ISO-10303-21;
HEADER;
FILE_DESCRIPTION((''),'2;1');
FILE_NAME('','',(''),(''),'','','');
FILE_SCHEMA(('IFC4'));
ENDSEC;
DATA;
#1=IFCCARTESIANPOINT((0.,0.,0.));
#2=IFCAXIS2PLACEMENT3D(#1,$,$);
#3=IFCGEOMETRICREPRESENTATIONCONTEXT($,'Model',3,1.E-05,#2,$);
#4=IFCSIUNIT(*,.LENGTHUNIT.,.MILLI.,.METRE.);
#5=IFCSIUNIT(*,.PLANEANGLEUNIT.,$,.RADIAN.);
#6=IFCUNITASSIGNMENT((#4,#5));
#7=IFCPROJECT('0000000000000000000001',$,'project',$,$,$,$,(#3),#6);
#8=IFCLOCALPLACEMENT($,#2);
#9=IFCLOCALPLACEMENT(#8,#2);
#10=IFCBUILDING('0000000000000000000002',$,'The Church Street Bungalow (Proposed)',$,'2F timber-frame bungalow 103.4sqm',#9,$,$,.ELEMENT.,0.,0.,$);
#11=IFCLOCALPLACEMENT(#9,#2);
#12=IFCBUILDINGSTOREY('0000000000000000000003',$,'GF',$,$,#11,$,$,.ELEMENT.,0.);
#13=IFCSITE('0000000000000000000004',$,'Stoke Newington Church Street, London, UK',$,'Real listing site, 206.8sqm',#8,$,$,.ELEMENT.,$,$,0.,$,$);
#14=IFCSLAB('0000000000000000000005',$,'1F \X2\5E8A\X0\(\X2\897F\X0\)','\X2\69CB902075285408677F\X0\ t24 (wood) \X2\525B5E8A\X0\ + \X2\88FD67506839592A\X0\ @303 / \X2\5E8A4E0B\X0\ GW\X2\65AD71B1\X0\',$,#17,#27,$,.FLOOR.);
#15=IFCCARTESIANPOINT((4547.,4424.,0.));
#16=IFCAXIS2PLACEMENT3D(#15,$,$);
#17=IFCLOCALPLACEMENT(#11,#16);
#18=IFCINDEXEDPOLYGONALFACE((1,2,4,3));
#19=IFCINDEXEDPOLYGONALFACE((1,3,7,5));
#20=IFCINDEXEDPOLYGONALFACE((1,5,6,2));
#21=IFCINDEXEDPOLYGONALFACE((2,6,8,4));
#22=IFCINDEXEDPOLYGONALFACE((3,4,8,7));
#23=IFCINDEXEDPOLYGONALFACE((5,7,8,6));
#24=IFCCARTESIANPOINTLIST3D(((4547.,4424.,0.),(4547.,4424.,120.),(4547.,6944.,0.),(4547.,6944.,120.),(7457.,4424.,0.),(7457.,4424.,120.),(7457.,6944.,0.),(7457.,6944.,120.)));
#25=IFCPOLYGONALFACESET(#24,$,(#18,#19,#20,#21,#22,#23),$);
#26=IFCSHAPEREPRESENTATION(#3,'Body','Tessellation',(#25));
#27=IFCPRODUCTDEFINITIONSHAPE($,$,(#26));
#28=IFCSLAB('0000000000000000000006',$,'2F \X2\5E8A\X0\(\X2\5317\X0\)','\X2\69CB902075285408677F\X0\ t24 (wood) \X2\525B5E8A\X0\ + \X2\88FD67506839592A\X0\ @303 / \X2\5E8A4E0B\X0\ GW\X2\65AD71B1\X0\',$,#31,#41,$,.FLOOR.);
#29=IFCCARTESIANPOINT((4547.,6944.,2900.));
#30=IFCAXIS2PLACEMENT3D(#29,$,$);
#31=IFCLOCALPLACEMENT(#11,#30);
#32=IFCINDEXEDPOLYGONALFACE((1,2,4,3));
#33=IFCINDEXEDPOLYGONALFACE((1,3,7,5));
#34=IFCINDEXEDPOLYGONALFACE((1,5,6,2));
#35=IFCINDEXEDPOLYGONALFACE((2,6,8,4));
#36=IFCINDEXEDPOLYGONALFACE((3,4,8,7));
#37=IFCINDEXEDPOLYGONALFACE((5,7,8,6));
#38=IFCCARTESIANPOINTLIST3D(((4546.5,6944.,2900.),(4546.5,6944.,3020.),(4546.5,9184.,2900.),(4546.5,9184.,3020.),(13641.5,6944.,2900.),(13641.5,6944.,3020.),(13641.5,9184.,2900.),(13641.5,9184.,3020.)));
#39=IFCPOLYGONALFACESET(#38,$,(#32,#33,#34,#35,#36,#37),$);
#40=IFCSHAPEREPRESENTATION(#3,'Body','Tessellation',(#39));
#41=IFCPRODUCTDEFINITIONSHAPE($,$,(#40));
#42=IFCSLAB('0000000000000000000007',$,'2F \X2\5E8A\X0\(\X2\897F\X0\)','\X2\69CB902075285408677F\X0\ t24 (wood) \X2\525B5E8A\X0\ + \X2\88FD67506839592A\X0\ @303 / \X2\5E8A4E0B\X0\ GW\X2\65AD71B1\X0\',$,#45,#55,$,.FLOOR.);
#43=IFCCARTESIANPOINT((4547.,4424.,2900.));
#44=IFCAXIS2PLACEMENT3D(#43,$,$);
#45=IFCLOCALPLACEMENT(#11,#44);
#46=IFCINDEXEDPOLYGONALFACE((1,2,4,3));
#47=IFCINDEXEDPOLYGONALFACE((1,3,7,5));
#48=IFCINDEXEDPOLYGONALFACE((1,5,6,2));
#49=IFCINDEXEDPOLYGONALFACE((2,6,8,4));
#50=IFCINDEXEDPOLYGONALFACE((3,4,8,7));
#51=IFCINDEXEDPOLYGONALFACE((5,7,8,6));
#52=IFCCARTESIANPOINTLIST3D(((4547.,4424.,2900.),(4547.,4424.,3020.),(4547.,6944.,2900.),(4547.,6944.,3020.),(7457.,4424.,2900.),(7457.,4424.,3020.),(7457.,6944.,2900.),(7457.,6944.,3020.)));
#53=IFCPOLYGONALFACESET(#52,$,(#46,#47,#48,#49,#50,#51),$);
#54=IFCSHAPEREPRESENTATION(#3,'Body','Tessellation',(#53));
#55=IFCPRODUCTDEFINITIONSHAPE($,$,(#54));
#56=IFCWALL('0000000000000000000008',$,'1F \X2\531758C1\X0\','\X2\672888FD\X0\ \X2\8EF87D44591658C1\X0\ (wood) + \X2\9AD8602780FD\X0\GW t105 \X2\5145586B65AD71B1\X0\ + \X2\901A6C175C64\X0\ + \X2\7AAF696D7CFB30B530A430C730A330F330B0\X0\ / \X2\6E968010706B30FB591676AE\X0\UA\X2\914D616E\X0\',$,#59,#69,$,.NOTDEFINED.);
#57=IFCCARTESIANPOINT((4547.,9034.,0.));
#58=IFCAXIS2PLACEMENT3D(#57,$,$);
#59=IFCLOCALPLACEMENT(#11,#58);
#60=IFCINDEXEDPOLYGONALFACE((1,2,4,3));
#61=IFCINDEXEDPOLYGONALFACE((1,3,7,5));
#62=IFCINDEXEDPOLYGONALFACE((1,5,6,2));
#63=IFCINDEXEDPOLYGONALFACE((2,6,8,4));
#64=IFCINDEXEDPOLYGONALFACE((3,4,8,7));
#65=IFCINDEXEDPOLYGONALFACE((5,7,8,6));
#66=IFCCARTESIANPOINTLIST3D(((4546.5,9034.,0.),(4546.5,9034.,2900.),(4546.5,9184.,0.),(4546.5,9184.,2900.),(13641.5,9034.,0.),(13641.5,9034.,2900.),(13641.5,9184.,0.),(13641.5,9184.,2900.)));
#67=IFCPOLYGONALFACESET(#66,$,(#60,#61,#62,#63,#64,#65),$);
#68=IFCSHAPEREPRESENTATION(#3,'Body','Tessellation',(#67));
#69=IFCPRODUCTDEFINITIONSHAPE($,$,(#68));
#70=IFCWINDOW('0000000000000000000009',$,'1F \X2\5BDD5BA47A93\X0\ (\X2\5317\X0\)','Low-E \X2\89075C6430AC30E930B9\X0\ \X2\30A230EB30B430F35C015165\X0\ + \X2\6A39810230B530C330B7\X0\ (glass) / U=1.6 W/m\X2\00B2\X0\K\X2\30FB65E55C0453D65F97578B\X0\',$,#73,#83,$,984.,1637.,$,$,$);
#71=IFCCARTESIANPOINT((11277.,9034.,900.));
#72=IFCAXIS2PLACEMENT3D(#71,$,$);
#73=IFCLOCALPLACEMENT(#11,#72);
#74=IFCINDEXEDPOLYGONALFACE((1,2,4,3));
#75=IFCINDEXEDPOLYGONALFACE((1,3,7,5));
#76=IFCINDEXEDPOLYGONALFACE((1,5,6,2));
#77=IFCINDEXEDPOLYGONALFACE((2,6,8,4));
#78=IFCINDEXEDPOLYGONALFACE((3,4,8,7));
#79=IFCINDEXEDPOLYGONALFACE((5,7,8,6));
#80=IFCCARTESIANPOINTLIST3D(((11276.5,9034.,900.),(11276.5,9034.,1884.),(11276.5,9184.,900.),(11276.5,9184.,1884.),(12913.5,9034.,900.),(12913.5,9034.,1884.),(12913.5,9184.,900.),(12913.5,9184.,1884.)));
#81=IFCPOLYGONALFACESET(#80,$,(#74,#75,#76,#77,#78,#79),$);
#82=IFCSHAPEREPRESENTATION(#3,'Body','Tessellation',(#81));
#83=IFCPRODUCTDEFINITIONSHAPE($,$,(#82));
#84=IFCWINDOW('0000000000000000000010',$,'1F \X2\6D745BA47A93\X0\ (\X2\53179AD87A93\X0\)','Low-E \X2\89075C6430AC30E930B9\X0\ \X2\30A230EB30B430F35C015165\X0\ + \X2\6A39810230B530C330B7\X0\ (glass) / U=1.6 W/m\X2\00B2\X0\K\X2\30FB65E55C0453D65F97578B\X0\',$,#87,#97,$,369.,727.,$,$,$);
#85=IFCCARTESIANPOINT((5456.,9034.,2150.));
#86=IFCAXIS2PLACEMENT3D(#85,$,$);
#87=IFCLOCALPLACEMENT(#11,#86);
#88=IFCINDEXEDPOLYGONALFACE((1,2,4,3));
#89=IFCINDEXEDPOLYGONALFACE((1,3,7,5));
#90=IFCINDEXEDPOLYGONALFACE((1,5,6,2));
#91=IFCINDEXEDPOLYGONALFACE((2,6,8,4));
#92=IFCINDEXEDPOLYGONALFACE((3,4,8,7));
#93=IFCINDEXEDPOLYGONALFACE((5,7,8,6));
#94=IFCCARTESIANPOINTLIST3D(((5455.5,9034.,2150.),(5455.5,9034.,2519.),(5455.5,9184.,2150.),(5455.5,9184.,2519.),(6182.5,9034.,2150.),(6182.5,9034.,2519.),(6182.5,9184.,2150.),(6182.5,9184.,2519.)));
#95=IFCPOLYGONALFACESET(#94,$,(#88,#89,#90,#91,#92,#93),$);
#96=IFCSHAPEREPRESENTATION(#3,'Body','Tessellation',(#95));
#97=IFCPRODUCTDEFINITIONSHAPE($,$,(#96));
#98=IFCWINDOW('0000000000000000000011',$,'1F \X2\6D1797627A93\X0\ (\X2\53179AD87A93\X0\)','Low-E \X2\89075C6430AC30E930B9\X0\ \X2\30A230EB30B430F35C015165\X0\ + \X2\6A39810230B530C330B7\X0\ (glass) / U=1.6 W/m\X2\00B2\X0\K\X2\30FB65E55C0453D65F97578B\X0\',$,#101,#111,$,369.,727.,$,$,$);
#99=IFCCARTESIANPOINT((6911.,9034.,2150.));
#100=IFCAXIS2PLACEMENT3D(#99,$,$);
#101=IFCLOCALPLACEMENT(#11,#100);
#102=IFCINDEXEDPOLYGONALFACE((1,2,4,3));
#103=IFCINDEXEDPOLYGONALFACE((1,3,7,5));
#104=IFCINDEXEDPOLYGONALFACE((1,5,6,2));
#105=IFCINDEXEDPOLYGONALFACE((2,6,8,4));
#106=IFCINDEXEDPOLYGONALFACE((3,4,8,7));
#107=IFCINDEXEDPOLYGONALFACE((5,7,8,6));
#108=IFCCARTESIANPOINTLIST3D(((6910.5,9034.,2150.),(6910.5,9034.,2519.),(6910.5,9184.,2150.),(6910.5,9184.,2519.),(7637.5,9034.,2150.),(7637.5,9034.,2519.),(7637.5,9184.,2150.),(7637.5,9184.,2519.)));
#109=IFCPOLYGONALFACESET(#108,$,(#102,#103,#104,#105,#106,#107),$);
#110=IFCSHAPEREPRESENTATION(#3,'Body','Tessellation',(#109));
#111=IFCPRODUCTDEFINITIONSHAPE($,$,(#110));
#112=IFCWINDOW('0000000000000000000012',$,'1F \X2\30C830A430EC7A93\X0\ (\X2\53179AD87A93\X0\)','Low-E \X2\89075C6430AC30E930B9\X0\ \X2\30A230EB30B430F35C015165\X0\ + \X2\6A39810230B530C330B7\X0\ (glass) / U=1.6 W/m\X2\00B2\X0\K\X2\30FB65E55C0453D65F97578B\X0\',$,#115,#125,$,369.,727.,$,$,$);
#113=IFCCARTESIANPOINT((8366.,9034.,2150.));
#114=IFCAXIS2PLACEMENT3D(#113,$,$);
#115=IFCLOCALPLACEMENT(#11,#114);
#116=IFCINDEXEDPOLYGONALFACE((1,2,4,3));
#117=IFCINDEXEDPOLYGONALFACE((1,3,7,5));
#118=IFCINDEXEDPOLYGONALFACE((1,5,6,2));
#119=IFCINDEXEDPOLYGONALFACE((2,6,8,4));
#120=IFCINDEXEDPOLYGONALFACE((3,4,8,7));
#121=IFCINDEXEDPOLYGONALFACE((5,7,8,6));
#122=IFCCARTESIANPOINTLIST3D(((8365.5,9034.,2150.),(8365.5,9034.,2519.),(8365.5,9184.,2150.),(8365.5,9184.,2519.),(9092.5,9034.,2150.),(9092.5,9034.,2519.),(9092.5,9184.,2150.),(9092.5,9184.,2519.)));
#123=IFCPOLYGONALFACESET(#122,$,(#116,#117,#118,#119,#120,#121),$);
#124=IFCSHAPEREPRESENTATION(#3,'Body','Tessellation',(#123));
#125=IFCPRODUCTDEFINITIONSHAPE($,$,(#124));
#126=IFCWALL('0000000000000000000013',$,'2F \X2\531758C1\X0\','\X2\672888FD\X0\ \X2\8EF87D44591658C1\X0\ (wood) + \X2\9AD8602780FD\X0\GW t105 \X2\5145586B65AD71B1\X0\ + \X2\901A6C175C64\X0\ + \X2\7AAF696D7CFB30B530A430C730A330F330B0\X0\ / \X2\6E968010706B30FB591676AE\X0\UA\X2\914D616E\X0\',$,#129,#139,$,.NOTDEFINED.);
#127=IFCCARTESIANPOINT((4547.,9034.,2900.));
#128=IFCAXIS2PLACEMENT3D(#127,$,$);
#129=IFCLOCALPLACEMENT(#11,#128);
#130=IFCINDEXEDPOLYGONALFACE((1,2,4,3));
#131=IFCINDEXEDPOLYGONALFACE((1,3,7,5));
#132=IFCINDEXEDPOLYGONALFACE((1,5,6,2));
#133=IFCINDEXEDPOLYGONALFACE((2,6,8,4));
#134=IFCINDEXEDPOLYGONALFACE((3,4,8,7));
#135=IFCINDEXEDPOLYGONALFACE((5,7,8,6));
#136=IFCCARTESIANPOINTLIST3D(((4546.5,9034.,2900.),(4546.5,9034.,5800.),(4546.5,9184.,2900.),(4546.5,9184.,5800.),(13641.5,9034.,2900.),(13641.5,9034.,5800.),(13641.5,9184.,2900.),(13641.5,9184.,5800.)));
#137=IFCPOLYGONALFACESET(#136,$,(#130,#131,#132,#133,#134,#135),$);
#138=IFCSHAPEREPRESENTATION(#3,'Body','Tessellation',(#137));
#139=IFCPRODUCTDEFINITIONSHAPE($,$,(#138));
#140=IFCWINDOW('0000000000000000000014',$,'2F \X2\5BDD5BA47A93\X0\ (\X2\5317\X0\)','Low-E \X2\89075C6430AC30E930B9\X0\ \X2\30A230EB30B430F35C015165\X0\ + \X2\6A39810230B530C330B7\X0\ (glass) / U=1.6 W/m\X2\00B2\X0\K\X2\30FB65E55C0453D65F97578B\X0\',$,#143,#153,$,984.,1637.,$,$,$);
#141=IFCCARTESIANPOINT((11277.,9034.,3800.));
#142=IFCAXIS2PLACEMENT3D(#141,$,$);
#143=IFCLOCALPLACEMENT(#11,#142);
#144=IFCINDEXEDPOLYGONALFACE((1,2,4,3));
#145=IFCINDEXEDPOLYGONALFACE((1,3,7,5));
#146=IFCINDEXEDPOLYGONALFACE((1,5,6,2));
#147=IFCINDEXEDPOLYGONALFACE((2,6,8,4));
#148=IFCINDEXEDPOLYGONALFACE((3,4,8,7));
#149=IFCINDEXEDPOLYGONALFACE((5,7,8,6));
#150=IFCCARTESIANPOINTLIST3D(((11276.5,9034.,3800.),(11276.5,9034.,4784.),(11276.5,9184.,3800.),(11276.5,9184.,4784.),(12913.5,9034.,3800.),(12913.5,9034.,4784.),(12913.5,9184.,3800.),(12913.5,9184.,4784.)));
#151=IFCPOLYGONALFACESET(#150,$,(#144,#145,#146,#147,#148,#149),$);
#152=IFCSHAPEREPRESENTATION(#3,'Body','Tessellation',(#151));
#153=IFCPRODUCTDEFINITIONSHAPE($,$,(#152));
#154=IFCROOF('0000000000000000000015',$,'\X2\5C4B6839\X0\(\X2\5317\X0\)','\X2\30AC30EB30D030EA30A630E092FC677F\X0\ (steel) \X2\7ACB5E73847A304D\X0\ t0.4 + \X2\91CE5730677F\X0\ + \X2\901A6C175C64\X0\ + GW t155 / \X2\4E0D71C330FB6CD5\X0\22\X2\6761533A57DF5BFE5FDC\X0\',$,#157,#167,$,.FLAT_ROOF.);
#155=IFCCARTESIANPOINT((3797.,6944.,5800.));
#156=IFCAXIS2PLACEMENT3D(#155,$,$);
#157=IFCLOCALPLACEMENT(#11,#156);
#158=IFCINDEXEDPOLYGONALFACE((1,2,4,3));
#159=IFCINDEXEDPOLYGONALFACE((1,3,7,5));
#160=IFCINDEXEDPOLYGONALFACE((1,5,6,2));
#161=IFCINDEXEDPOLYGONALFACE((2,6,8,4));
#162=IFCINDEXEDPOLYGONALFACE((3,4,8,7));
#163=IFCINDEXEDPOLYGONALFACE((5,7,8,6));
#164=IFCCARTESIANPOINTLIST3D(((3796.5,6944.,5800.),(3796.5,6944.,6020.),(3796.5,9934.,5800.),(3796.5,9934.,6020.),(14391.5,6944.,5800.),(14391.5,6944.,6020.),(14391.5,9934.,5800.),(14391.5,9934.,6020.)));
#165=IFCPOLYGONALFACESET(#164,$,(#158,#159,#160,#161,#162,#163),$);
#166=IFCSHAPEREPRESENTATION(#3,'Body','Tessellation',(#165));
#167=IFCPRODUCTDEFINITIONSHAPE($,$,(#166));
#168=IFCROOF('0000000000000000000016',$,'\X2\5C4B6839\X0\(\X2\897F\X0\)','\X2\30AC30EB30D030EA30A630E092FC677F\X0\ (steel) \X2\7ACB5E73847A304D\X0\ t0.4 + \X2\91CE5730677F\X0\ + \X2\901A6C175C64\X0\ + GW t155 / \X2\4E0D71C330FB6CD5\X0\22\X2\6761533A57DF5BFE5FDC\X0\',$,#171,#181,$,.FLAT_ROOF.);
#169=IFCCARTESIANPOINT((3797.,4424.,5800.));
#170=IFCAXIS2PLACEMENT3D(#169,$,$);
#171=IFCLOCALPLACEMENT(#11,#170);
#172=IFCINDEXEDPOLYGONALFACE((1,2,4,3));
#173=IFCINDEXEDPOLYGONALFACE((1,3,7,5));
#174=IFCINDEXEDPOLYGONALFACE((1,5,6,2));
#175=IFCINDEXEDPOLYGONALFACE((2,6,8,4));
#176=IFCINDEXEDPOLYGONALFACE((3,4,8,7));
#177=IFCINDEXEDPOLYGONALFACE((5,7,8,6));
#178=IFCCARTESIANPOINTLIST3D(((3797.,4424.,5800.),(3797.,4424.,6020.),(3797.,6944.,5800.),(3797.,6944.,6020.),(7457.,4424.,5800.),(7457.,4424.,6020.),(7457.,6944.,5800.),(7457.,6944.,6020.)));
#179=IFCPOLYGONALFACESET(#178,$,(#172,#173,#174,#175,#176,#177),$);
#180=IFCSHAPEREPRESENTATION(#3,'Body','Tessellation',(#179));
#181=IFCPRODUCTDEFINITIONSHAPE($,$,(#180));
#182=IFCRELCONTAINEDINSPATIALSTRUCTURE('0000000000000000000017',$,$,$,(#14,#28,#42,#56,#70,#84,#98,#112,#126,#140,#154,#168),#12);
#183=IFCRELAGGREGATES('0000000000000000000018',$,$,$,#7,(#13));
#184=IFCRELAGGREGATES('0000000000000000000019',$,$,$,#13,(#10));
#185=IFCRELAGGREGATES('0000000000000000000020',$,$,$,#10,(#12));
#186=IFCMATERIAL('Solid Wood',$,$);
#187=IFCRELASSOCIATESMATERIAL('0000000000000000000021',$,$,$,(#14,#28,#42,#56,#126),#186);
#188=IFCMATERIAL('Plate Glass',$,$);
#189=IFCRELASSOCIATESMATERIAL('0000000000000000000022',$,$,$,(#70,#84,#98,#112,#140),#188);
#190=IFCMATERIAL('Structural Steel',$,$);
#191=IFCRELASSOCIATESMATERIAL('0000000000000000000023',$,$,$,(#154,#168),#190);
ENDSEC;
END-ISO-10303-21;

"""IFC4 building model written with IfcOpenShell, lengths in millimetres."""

from ifc_helpers import new_model, si_unit, frame, frame_2d, origin, place, context, project, spatial, rectangle, extrude, material, element, fill, save


model = new_model("IFC4")

# Units and contexts
model_context = context("Model", 3, precision=1e-05, world=origin())
ifc_project = project(units=[si_unit("LENGTHUNIT", "METRE", prefix="MILLI"), si_unit("PLANEANGLEUNIT", "RADIAN")], contexts=[model_context])

# Site, building, storey
site_placement = place(None, origin())
site = spatial("IfcSite", under=ifc_project, at=site_placement, Name="Stoke Newington Church Street, London, UK", ObjectType="Real listing site, 206.8sqm", CompositionType="ELEMENT", RefElevation=0.0)
building_placement = place(site_placement, origin())
building = spatial("IfcBuilding", under=site, at=building_placement, Name="The Church Street Bungalow (Proposed)", ObjectType="2F timber-frame bungalow 103.4sqm", CompositionType="ELEMENT", ElevationOfRefHeight=0.0, ElevationOfTerrain=0.0)
storey_placement = place(building_placement, origin())
storey = spatial("IfcBuildingStorey", under=building, at=storey_placement, Name="GF", CompositionType="ELEMENT", Elevation=0.0)

# Slabs
ifc_material_1 = material(Name="Solid Wood")
slab_1_placement = place(storey_placement, frame((4547.0, 4424.0, 0.0)))
element("IfcSlab", 1, at=slab_1_placement, inside=storey, material=ifc_material_1, Name="1F 床(西)", Description="構造用合板 t24 (wood) 剛床 + 製材根太 @303 / 床下 GW断熱", PredefinedType="FLOOR", context=model_context, shape_type="SweptSolid", body=[
    extrude(rectangle(XDim=2910.0, YDim=2520.0, at=frame_2d((1455.0, 1260.0))), frame((4547.0, 4424.0, 0.0)), (0.0, 0.0, 1.0), 120.0),
])
slab_2_placement = place(storey_placement, frame((4547.0, 6944.0, 2900.0)))
element("IfcSlab", 2, at=slab_2_placement, inside=storey, material=ifc_material_1, Name="2F 床(北)", Description="構造用合板 t24 (wood) 剛床 + 製材根太 @303 / 床下 GW断熱", PredefinedType="FLOOR", context=model_context, shape_type="SweptSolid", body=[
    extrude(rectangle(XDim=9095.0, YDim=2240.0, at=frame_2d((4547.0, 1120.0))), frame((4547.0, 6944.0, 2900.0)), (0.0, 0.0, 1.0), 120.0),
])
slab_3_placement = place(storey_placement, frame((4547.0, 4424.0, 2900.0)))
element("IfcSlab", 3, at=slab_3_placement, inside=storey, material=ifc_material_1, Name="2F 床(西)", Description="構造用合板 t24 (wood) 剛床 + 製材根太 @303 / 床下 GW断熱", PredefinedType="FLOOR", context=model_context, shape_type="SweptSolid", body=[
    extrude(rectangle(XDim=2910.0, YDim=2520.0, at=frame_2d((1455.0, 1260.0))), frame((4547.0, 4424.0, 2900.0)), (0.0, 0.0, 1.0), 120.0),
])

# Wall, openings, windows
wall_1_placement = place(storey_placement, frame((4547.0, 9034.0, 0.0)))
wall_1 = element("IfcWall", 4, at=wall_1_placement, inside=storey, material=ifc_material_1, Name="1F 北壁", Description="木製 軸組外壁 (wood) + 高性能GW t105 充填断熱 + 通気層 + 窯業系サイディング / 準耐火・外皮UA配慮", PredefinedType="NOTDEFINED", context=model_context, shape_type="SweptSolid", body=[
    extrude(rectangle(XDim=9095.0, YDim=150.0, at=frame_2d((4547.0, 75.0))), frame((4547.0, 9034.0, 0.0)), (0.0, 0.0, 1.0), 2900.0),
])
opening_1_placement = place(storey_placement, frame((11277.0, 9034.0, 900.0)))
opening_1 = element("IfcOpeningElement", 5, at=opening_1_placement, cuts=wall_1, PredefinedType="NOTDEFINED", context=model_context, shape_type="SweptSolid", body=[
    extrude(rectangle(XDim=1637.0, YDim=150.0, at=frame_2d((818.0, 75.0))), frame((11277.0, 9034.0, 900.0)), (0.0, 0.0, 1.0), 984.0),
])
opening_2_placement = place(storey_placement, frame((5456.0, 9034.0, 2150.0)))
opening_2 = element("IfcOpeningElement", 6, at=opening_2_placement, cuts=wall_1, PredefinedType="NOTDEFINED", context=model_context, shape_type="SweptSolid", body=[
    extrude(rectangle(XDim=727.0, YDim=150.0, at=frame_2d((363.0, 75.0))), frame((5456.0, 9034.0, 2150.0)), (0.0, 0.0, 1.0), 369.0),
])
opening_3_placement = place(storey_placement, frame((6911.0, 9034.0, 2150.0)))
opening_3 = element("IfcOpeningElement", 7, at=opening_3_placement, cuts=wall_1, PredefinedType="NOTDEFINED", context=model_context, shape_type="SweptSolid", body=[
    extrude(rectangle(XDim=727.0, YDim=150.0, at=frame_2d((363.0, 75.0))), frame((6911.0, 9034.0, 2150.0)), (0.0, 0.0, 1.0), 369.0),
])
opening_4_placement = place(storey_placement, frame((8366.0, 9034.0, 2150.0)))
opening_4 = element("IfcOpeningElement", 8, at=opening_4_placement, cuts=wall_1, PredefinedType="NOTDEFINED", context=model_context, shape_type="SweptSolid", body=[
    extrude(rectangle(XDim=727.0, YDim=150.0, at=frame_2d((363.0, 75.0))), frame((8366.0, 9034.0, 2150.0)), (0.0, 0.0, 1.0), 369.0),
])
ifc_material_2 = material(Name="Plate Glass")
window_1_placement = place(storey_placement, frame((11277.0, 9034.0, 900.0)))
window_1 = element("IfcWindow", 9, at=window_1_placement, inside=storey, material=ifc_material_2, Name="1F 寝室窓 (北)", Description="Low-E 複層ガラス アルゴン封入 + 樹脂サッシ (glass) / U=1.6 W/m²K・日射取得型", OverallHeight=984.0, OverallWidth=1637.0, context=model_context, shape_type="SweptSolid", body=[
    extrude(rectangle(XDim=1637.0, YDim=150.0, at=frame_2d((818.0, 75.0))), frame((11277.0, 9034.0, 900.0)), (0.0, 0.0, 1.0), 984.0),
])
fill(opening_1, window_1)
window_2_placement = place(storey_placement, frame((5456.0, 9034.0, 2150.0)))
window_2 = element("IfcWindow", 10, at=window_2_placement, inside=storey, material=ifc_material_2, Name="1F 浴室窓 (北高窓)", Description="Low-E 複層ガラス アルゴン封入 + 樹脂サッシ (glass) / U=1.6 W/m²K・日射取得型", OverallHeight=369.0, OverallWidth=727.0, context=model_context, shape_type="SweptSolid", body=[
    extrude(rectangle(XDim=727.0, YDim=150.0, at=frame_2d((363.0, 75.0))), frame((5456.0, 9034.0, 2150.0)), (0.0, 0.0, 1.0), 369.0),
])
fill(opening_2, window_2)
window_3_placement = place(storey_placement, frame((6911.0, 9034.0, 2150.0)))
window_3 = element("IfcWindow", 11, at=window_3_placement, inside=storey, material=ifc_material_2, Name="1F 洗面窓 (北高窓)", Description="Low-E 複層ガラス アルゴン封入 + 樹脂サッシ (glass) / U=1.6 W/m²K・日射取得型", OverallHeight=369.0, OverallWidth=727.0, context=model_context, shape_type="SweptSolid", body=[
    extrude(rectangle(XDim=727.0, YDim=150.0, at=frame_2d((363.0, 75.0))), frame((6911.0, 9034.0, 2150.0)), (0.0, 0.0, 1.0), 369.0),
])
fill(opening_3, window_3)
window_4_placement = place(storey_placement, frame((8366.0, 9034.0, 2150.0)))
window_4 = element("IfcWindow", 12, at=window_4_placement, inside=storey, material=ifc_material_2, Name="1F トイレ窓 (北高窓)", Description="Low-E 複層ガラス アルゴン封入 + 樹脂サッシ (glass) / U=1.6 W/m²K・日射取得型", OverallHeight=369.0, OverallWidth=727.0, context=model_context, shape_type="SweptSolid", body=[
    extrude(rectangle(XDim=727.0, YDim=150.0, at=frame_2d((363.0, 75.0))), frame((8366.0, 9034.0, 2150.0)), (0.0, 0.0, 1.0), 369.0),
])
fill(opening_4, window_4)

# Wall, opening, window
wall_2_placement = place(storey_placement, frame((4547.0, 9034.0, 2900.0)))
wall_2 = element("IfcWall", 13, at=wall_2_placement, inside=storey, material=ifc_material_1, Name="2F 北壁", Description="木製 軸組外壁 (wood) + 高性能GW t105 充填断熱 + 通気層 + 窯業系サイディング / 準耐火・外皮UA配慮", PredefinedType="NOTDEFINED", context=model_context, shape_type="SweptSolid", body=[
    extrude(rectangle(XDim=9095.0, YDim=150.0, at=frame_2d((4547.0, 75.0))), frame((4547.0, 9034.0, 2900.0)), (0.0, 0.0, 1.0), 2900.0),
])
opening_5_placement = place(storey_placement, frame((11277.0, 9034.0, 3800.0)))
opening_5 = element("IfcOpeningElement", 14, at=opening_5_placement, cuts=wall_2, PredefinedType="NOTDEFINED", context=model_context, shape_type="SweptSolid", body=[
    extrude(rectangle(XDim=1637.0, YDim=150.0, at=frame_2d((818.0, 75.0))), frame((11277.0, 9034.0, 3800.0)), (0.0, 0.0, 1.0), 984.0),
])
window_5_placement = place(storey_placement, frame((11277.0, 9034.0, 3800.0)))
window_5 = element("IfcWindow", 15, at=window_5_placement, inside=storey, material=ifc_material_2, Name="2F 寝室窓 (北)", Description="Low-E 複層ガラス アルゴン封入 + 樹脂サッシ (glass) / U=1.6 W/m²K・日射取得型", OverallHeight=984.0, OverallWidth=1637.0, context=model_context, shape_type="SweptSolid", body=[
    extrude(rectangle(XDim=1637.0, YDim=150.0, at=frame_2d((818.0, 75.0))), frame((11277.0, 9034.0, 3800.0)), (0.0, 0.0, 1.0), 984.0),
])
fill(opening_5, window_5)

# Roofs
ifc_material_3 = material(Name="Structural Steel")
for number, where, name in (
    (16, (3797.0, 6944.0, 5800.0), "屋根(北)"),
):
    element("IfcRoof", number, at=place(storey_placement, frame(where)), inside=storey, material=ifc_material_3, Name=name, Description="ガルバリウム鋼板 (steel) 立平葺き t0.4 + 野地板 + 通気層 + GW t155 / 不燃・法22条区域対応", PredefinedType="FLAT_ROOF", context=model_context, shape_type="SweptSolid", body=[
        extrude(rectangle(XDim=10595.0, YDim=2990.0, at=frame_2d((5297.0, 1495.0))), frame((3797.0, 6944.0, 5800.0)), (0.0, 0.0, 1.0), 220.0),
    ])
roof_placement = place(storey_placement, frame((3797.0, 4424.0, 5800.0)))
element("IfcRoof", 17, at=roof_placement, inside=storey, material=ifc_material_3, Name="屋根(西)", Description="ガルバリウム鋼板 (steel) 立平葺き t0.4 + 野地板 + 通気層 + GW t155 / 不燃・法22条区域対応", PredefinedType="FLAT_ROOF", context=model_context, shape_type="SweptSolid", body=[
    extrude(rectangle(XDim=3660.0, YDim=2520.0, at=frame_2d((1830.0, 1260.0))), frame((3797.0, 4424.0, 5800.0)), (0.0, 0.0, 1.0), 220.0),
])

save(model, "model.ifc")
